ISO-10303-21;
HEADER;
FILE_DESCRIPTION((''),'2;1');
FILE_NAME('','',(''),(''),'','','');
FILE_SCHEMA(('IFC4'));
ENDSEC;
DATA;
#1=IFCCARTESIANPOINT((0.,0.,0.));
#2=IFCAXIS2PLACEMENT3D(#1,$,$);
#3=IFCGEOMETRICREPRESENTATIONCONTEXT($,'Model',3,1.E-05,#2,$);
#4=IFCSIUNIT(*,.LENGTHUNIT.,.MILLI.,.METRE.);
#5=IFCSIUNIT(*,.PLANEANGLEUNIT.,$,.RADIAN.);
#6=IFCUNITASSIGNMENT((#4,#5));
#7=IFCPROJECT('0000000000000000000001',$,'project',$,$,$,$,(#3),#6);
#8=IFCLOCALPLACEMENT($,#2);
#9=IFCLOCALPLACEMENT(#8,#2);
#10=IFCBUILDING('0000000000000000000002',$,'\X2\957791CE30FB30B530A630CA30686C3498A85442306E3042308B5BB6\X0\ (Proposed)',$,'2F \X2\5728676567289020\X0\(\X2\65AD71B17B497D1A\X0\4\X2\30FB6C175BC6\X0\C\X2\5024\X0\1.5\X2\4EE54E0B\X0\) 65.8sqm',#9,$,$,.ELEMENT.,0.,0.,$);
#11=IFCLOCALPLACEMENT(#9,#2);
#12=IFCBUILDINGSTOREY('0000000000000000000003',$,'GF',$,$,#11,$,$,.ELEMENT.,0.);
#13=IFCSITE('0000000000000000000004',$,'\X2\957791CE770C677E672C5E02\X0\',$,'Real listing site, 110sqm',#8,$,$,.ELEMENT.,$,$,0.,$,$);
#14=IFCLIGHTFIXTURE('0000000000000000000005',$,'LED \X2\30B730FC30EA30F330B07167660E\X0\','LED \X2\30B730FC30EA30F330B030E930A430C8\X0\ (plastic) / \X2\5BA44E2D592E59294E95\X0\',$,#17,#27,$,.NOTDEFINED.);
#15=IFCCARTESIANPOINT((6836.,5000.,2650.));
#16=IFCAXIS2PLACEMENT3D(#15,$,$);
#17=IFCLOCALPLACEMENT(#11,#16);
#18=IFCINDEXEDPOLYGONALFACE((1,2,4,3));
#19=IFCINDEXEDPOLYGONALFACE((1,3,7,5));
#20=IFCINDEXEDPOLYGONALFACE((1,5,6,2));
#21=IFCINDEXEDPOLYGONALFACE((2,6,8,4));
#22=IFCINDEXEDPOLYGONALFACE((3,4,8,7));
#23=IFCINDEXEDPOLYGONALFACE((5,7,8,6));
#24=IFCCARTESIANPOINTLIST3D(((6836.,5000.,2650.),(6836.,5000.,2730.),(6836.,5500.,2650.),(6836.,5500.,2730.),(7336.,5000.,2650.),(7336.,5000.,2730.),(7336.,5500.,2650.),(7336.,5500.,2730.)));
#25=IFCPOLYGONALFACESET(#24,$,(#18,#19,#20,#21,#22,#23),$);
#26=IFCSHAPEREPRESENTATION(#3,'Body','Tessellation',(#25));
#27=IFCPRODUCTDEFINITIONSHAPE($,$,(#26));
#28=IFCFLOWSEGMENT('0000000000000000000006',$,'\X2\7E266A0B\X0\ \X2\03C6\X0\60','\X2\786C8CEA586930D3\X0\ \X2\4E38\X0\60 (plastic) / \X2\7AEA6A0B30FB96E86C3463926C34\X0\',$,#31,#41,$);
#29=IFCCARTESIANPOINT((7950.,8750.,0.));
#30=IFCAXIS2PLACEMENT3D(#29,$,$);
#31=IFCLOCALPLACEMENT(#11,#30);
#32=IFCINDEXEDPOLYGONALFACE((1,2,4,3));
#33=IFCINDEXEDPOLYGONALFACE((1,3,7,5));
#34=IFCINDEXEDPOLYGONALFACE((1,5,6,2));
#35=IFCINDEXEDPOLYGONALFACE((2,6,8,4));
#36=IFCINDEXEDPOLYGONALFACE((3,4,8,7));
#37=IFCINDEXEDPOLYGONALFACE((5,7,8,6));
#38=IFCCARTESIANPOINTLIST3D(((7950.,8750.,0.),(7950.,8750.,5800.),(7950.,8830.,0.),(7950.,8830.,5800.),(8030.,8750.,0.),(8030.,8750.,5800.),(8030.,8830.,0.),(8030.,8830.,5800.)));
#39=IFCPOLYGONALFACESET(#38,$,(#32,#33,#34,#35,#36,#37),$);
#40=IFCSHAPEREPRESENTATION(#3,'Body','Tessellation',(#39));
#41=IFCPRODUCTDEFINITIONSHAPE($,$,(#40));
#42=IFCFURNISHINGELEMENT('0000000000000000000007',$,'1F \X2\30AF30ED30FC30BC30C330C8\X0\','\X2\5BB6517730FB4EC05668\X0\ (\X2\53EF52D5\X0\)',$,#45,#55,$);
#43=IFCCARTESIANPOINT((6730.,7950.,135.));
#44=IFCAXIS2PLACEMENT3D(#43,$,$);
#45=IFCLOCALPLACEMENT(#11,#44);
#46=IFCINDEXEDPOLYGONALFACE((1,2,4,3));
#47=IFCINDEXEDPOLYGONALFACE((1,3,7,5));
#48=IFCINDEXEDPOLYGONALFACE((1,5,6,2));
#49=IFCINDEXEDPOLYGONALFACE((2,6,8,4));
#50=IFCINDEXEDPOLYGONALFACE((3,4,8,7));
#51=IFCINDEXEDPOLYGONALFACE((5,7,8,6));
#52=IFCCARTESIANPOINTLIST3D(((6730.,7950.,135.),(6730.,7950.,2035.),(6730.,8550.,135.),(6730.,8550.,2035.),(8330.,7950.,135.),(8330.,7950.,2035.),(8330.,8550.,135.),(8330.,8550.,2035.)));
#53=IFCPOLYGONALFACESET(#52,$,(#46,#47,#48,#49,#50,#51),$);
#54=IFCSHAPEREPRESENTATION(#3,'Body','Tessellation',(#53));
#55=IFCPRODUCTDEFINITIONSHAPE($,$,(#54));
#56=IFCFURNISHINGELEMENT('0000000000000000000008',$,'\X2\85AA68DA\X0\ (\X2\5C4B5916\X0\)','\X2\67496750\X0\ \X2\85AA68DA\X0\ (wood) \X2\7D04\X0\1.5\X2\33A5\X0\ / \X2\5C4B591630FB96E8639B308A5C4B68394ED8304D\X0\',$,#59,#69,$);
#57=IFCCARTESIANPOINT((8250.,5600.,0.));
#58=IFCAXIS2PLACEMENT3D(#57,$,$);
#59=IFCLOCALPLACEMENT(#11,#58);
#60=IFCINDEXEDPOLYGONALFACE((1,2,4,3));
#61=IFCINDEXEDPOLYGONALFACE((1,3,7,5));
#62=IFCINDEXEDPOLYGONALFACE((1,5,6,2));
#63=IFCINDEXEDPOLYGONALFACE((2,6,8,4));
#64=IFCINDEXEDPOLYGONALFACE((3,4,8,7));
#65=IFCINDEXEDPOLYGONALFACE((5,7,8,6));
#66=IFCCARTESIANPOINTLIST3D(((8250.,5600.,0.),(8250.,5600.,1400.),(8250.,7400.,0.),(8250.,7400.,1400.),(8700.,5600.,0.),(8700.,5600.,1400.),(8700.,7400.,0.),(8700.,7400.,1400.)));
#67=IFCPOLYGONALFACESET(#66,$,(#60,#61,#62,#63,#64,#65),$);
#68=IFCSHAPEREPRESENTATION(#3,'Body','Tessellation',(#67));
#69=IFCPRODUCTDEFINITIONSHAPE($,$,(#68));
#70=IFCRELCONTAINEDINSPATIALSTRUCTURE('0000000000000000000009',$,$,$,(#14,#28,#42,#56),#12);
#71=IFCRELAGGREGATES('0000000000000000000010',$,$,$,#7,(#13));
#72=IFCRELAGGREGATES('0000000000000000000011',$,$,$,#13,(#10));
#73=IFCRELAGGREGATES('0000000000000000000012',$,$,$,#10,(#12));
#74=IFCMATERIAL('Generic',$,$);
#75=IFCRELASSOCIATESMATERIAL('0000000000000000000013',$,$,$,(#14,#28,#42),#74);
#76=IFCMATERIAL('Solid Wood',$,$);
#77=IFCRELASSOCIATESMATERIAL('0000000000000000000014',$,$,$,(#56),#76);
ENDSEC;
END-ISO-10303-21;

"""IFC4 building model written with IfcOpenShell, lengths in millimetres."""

from ifc_helpers import new_model, si_unit, frame, frame_2d, origin, place, context, project, spatial, rectangle, extrude, material, element, save


model = new_model("IFC4")

# Units and contexts
model_context = context("Model", 3, precision=1e-05, world=origin())
ifc_project = project(units=[si_unit("LENGTHUNIT", "METRE", prefix="MILLI"), si_unit("PLANEANGLEUNIT", "RADIAN")], contexts=[model_context])

# Site, building, storey
site_placement = place(None, origin())
site = spatial("IfcSite", under=ifc_project, at=site_placement, Name="長野県松本市", ObjectType="Real listing site, 110sqm", CompositionType="ELEMENT", RefElevation=0.0)
building_placement = place(site_placement, origin())
building = spatial("IfcBuilding", under=site, at=building_placement, Name="長野・サウナと水風呂のある家 (Proposed)", ObjectType="2F 在来木造(断熱等級4・気密C値1.5以下) 65.8sqm", CompositionType="ELEMENT", ElevationOfRefHeight=0.0, ElevationOfTerrain=0.0)
storey_placement = place(building_placement, origin())
storey = spatial("IfcBuildingStorey", under=building, at=storey_placement, Name="GF", CompositionType="ELEMENT", Elevation=0.0)

# Shared definitions
ifc_material_1 = material(Name="Solid Wood")

# Shared definitions
ifc_material_2 = material(Name="Generic")

# Light fixture
light_fixture_placement = place(storey_placement, frame((6836.0, 5000.0, 2650.0)))
element("IfcLightFixture", 1, at=light_fixture_placement, inside=storey, material=ifc_material_2, Name="LED シーリング照明", Description="LED シーリングライト (plastic) / 室中央天井", PredefinedType="NOTDEFINED", context=model_context, shape_type="SweptSolid", body=[
    extrude(rectangle(XDim=500.0, YDim=500.0, at=frame_2d((250.0, 250.0))), frame((6836.0, 5000.0, 2650.0)), (0.0, 0.0, 1.0), 80.0),
])

# Flow segment
flow_segment_placement = place(storey_placement, frame((7950.0, 8750.0, 0.0)))
element("IfcFlowSegment", 2, at=flow_segment_placement, inside=storey, material=ifc_material_2, Name="縦樋 φ60", Description="硬質塩ビ 丸60 (plastic) / 竪樋・雨水排水", context=model_context, shape_type="SweptSolid", body=[
    extrude(rectangle(XDim=80.0, YDim=80.0, at=frame_2d((40.0, 40.0))), frame((7950.0, 8750.0, 0.0)), (0.0, 0.0, 1.0), 5800.0),
])

# Furnishing elements
furnishing_1_placement = place(storey_placement, frame((6730.0, 7950.0, 135.0)))
element("IfcFurnishingElement", 3, at=furnishing_1_placement, inside=storey, material=ifc_material_2, Name="1F クローゼット", Description="家具・什器 (可動)", context=model_context, shape_type="SweptSolid", body=[
    extrude(rectangle(XDim=1600.0, YDim=600.0, at=frame_2d((800.0, 300.0))), frame((6730.0, 7950.0, 135.0)), (0.0, 0.0, 1.0), 1900.0),
])
furnishing_2_placement = place(storey_placement, frame((8250.0, 5600.0, 0.0)))
element("IfcFurnishingElement", 4, at=furnishing_2_placement, inside=storey, material=ifc_material_1, Name="薪棚 (屋外)", Description="杉材 薪棚 (wood) 約1.5㎥ / 屋外・雨掛り屋根付き", context=model_context, shape_type="SweptSolid", body=[
    extrude(rectangle(XDim=450.0, YDim=1800.0, at=frame_2d((225.0, 900.0))), frame((8250.0, 5600.0, 0.0)), (0.0, 0.0, 1.0), 1400.0),
])

save(model, "model.ifc")
